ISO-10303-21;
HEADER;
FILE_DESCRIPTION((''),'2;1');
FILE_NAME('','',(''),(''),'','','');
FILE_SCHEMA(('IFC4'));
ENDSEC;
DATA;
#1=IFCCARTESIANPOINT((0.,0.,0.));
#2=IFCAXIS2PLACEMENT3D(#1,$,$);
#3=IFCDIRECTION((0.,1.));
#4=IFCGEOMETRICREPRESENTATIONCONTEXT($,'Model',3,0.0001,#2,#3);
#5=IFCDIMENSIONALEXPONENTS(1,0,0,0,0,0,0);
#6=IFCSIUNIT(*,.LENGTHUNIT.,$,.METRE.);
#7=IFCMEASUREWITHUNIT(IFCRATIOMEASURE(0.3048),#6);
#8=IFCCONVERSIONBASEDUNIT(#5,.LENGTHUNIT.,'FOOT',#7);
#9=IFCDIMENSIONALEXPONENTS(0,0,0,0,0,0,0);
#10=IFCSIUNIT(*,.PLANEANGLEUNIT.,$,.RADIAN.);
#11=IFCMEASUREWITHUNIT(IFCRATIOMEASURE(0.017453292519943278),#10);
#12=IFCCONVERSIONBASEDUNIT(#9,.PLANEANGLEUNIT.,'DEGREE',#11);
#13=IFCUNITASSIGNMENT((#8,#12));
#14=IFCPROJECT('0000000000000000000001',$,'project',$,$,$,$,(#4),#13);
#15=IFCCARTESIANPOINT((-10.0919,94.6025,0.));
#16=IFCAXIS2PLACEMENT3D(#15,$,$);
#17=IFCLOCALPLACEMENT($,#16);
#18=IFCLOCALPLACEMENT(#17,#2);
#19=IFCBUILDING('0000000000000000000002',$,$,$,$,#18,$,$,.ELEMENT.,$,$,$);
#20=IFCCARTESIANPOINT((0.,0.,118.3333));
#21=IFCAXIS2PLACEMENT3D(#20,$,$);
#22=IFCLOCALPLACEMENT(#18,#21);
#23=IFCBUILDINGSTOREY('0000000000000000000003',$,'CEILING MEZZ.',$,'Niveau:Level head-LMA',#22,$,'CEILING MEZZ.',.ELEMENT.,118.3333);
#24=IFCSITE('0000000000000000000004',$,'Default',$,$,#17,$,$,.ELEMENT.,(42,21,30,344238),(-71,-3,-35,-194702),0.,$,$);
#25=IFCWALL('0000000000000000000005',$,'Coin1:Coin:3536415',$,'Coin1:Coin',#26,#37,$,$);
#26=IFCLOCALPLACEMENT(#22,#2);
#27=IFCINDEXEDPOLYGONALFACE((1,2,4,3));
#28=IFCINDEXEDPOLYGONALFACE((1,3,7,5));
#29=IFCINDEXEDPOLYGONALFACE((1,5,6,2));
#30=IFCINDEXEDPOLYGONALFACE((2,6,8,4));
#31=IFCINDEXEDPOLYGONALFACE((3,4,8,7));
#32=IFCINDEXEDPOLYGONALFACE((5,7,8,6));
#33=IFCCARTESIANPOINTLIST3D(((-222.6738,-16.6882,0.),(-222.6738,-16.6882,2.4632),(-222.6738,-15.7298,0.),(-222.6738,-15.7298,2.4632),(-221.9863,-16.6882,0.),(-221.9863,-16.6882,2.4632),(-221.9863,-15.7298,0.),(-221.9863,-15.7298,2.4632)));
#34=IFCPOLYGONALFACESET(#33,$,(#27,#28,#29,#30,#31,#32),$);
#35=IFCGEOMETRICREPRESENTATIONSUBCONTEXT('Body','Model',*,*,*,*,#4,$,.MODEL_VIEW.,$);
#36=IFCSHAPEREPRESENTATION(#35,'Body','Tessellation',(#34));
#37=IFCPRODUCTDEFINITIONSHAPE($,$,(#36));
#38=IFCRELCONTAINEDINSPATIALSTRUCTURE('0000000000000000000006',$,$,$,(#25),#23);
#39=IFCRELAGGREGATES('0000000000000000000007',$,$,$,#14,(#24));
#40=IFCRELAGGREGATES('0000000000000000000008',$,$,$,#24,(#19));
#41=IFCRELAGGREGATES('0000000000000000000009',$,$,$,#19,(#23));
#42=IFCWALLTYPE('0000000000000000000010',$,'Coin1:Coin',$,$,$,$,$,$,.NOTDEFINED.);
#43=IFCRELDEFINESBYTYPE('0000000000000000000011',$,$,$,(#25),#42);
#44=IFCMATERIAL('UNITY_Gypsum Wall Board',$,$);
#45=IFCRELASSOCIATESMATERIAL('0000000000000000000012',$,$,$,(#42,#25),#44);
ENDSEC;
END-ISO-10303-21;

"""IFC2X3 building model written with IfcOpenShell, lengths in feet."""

from ifc_helpers import new_model, entity, si_unit, converted_unit, direction, frame, frame_2d, origin, place, context, subcontext, project, spatial, rectangle, extrude, material, type_object, element, save


model = new_model("IFC2X3")

# Units and contexts
model_context = context("Model", 3, precision=0.0001, world=origin(), true_north=direction((0.0, 1.0)))
body_context = subcontext(model_context, "Body", "Model", "MODEL_VIEW")
ifc_project = project(units=[converted_unit("LENGTHUNIT", "FOOT", entity("IfcRatioMeasure", 0.3048), si_unit("LENGTHUNIT", "METRE"), dimensions=[1, 0, 0, 0, 0, 0, 0]), converted_unit("PLANEANGLEUNIT", "DEGREE", entity("IfcRatioMeasure", 0.017453292519943278), si_unit("PLANEANGLEUNIT", "RADIAN"), dimensions=[0, 0, 0, 0, 0, 0, 0])], contexts=[model_context])

# Site, building, storey
site_placement = place(None, frame((-10.0919, 94.6025, 0.0)))
site = spatial("IfcSite", under=ifc_project, at=site_placement, Name="Default", CompositionType="ELEMENT", RefLatitude=(42, 21, 30, 344238), RefLongitude=(-71, -3, -35, -194702), RefElevation=0.0)
building_placement = place(site_placement, origin())
building = spatial("IfcBuilding", under=site, at=building_placement, CompositionType="ELEMENT")
storey_placement = place(building_placement, frame((0.0, 0.0, 118.3333)))
storey = spatial("IfcBuildingStorey", under=building, at=storey_placement, Name="CEILING MEZZ.", ObjectType="Niveau:Level head-LMA", LongName="CEILING MEZZ.", CompositionType="ELEMENT", Elevation=118.3333)

# Wall
ifc_material = material(Name="UNITY_Gypsum Wall Board")
wall_type = type_object("IfcWallType", Name="Coin1:Coin", PredefinedType="NOTDEFINED", material=ifc_material)
wall_placement = place(storey_placement, frame((-222.6738, -16.6882, 0.0), z_axis=(0.0, 0.0, 1.0), x_axis=(0.0, 1.0, 0.0)))
element("IfcWall", 1, at=wall_placement, inside=storey, type_object=wall_type, material=ifc_material, Name="Coin1:Coin:3536415", ObjectType="Coin1:Coin", context=body_context, shape_type="SweptSolid", body=[
    extrude(rectangle(XDim=0.6875, YDim=0.9583, at=frame_2d((0.0, 0.0), x_axis=(1.0, 0.0))), frame((0.4792, -0.3438, 0.0), z_axis=(0.0, 0.0, 1.0), x_axis=(0.0, 1.0, 0.0)), (0.0, 0.0, 1.0), 2.4632),
])

save(model, "model.ifc")
